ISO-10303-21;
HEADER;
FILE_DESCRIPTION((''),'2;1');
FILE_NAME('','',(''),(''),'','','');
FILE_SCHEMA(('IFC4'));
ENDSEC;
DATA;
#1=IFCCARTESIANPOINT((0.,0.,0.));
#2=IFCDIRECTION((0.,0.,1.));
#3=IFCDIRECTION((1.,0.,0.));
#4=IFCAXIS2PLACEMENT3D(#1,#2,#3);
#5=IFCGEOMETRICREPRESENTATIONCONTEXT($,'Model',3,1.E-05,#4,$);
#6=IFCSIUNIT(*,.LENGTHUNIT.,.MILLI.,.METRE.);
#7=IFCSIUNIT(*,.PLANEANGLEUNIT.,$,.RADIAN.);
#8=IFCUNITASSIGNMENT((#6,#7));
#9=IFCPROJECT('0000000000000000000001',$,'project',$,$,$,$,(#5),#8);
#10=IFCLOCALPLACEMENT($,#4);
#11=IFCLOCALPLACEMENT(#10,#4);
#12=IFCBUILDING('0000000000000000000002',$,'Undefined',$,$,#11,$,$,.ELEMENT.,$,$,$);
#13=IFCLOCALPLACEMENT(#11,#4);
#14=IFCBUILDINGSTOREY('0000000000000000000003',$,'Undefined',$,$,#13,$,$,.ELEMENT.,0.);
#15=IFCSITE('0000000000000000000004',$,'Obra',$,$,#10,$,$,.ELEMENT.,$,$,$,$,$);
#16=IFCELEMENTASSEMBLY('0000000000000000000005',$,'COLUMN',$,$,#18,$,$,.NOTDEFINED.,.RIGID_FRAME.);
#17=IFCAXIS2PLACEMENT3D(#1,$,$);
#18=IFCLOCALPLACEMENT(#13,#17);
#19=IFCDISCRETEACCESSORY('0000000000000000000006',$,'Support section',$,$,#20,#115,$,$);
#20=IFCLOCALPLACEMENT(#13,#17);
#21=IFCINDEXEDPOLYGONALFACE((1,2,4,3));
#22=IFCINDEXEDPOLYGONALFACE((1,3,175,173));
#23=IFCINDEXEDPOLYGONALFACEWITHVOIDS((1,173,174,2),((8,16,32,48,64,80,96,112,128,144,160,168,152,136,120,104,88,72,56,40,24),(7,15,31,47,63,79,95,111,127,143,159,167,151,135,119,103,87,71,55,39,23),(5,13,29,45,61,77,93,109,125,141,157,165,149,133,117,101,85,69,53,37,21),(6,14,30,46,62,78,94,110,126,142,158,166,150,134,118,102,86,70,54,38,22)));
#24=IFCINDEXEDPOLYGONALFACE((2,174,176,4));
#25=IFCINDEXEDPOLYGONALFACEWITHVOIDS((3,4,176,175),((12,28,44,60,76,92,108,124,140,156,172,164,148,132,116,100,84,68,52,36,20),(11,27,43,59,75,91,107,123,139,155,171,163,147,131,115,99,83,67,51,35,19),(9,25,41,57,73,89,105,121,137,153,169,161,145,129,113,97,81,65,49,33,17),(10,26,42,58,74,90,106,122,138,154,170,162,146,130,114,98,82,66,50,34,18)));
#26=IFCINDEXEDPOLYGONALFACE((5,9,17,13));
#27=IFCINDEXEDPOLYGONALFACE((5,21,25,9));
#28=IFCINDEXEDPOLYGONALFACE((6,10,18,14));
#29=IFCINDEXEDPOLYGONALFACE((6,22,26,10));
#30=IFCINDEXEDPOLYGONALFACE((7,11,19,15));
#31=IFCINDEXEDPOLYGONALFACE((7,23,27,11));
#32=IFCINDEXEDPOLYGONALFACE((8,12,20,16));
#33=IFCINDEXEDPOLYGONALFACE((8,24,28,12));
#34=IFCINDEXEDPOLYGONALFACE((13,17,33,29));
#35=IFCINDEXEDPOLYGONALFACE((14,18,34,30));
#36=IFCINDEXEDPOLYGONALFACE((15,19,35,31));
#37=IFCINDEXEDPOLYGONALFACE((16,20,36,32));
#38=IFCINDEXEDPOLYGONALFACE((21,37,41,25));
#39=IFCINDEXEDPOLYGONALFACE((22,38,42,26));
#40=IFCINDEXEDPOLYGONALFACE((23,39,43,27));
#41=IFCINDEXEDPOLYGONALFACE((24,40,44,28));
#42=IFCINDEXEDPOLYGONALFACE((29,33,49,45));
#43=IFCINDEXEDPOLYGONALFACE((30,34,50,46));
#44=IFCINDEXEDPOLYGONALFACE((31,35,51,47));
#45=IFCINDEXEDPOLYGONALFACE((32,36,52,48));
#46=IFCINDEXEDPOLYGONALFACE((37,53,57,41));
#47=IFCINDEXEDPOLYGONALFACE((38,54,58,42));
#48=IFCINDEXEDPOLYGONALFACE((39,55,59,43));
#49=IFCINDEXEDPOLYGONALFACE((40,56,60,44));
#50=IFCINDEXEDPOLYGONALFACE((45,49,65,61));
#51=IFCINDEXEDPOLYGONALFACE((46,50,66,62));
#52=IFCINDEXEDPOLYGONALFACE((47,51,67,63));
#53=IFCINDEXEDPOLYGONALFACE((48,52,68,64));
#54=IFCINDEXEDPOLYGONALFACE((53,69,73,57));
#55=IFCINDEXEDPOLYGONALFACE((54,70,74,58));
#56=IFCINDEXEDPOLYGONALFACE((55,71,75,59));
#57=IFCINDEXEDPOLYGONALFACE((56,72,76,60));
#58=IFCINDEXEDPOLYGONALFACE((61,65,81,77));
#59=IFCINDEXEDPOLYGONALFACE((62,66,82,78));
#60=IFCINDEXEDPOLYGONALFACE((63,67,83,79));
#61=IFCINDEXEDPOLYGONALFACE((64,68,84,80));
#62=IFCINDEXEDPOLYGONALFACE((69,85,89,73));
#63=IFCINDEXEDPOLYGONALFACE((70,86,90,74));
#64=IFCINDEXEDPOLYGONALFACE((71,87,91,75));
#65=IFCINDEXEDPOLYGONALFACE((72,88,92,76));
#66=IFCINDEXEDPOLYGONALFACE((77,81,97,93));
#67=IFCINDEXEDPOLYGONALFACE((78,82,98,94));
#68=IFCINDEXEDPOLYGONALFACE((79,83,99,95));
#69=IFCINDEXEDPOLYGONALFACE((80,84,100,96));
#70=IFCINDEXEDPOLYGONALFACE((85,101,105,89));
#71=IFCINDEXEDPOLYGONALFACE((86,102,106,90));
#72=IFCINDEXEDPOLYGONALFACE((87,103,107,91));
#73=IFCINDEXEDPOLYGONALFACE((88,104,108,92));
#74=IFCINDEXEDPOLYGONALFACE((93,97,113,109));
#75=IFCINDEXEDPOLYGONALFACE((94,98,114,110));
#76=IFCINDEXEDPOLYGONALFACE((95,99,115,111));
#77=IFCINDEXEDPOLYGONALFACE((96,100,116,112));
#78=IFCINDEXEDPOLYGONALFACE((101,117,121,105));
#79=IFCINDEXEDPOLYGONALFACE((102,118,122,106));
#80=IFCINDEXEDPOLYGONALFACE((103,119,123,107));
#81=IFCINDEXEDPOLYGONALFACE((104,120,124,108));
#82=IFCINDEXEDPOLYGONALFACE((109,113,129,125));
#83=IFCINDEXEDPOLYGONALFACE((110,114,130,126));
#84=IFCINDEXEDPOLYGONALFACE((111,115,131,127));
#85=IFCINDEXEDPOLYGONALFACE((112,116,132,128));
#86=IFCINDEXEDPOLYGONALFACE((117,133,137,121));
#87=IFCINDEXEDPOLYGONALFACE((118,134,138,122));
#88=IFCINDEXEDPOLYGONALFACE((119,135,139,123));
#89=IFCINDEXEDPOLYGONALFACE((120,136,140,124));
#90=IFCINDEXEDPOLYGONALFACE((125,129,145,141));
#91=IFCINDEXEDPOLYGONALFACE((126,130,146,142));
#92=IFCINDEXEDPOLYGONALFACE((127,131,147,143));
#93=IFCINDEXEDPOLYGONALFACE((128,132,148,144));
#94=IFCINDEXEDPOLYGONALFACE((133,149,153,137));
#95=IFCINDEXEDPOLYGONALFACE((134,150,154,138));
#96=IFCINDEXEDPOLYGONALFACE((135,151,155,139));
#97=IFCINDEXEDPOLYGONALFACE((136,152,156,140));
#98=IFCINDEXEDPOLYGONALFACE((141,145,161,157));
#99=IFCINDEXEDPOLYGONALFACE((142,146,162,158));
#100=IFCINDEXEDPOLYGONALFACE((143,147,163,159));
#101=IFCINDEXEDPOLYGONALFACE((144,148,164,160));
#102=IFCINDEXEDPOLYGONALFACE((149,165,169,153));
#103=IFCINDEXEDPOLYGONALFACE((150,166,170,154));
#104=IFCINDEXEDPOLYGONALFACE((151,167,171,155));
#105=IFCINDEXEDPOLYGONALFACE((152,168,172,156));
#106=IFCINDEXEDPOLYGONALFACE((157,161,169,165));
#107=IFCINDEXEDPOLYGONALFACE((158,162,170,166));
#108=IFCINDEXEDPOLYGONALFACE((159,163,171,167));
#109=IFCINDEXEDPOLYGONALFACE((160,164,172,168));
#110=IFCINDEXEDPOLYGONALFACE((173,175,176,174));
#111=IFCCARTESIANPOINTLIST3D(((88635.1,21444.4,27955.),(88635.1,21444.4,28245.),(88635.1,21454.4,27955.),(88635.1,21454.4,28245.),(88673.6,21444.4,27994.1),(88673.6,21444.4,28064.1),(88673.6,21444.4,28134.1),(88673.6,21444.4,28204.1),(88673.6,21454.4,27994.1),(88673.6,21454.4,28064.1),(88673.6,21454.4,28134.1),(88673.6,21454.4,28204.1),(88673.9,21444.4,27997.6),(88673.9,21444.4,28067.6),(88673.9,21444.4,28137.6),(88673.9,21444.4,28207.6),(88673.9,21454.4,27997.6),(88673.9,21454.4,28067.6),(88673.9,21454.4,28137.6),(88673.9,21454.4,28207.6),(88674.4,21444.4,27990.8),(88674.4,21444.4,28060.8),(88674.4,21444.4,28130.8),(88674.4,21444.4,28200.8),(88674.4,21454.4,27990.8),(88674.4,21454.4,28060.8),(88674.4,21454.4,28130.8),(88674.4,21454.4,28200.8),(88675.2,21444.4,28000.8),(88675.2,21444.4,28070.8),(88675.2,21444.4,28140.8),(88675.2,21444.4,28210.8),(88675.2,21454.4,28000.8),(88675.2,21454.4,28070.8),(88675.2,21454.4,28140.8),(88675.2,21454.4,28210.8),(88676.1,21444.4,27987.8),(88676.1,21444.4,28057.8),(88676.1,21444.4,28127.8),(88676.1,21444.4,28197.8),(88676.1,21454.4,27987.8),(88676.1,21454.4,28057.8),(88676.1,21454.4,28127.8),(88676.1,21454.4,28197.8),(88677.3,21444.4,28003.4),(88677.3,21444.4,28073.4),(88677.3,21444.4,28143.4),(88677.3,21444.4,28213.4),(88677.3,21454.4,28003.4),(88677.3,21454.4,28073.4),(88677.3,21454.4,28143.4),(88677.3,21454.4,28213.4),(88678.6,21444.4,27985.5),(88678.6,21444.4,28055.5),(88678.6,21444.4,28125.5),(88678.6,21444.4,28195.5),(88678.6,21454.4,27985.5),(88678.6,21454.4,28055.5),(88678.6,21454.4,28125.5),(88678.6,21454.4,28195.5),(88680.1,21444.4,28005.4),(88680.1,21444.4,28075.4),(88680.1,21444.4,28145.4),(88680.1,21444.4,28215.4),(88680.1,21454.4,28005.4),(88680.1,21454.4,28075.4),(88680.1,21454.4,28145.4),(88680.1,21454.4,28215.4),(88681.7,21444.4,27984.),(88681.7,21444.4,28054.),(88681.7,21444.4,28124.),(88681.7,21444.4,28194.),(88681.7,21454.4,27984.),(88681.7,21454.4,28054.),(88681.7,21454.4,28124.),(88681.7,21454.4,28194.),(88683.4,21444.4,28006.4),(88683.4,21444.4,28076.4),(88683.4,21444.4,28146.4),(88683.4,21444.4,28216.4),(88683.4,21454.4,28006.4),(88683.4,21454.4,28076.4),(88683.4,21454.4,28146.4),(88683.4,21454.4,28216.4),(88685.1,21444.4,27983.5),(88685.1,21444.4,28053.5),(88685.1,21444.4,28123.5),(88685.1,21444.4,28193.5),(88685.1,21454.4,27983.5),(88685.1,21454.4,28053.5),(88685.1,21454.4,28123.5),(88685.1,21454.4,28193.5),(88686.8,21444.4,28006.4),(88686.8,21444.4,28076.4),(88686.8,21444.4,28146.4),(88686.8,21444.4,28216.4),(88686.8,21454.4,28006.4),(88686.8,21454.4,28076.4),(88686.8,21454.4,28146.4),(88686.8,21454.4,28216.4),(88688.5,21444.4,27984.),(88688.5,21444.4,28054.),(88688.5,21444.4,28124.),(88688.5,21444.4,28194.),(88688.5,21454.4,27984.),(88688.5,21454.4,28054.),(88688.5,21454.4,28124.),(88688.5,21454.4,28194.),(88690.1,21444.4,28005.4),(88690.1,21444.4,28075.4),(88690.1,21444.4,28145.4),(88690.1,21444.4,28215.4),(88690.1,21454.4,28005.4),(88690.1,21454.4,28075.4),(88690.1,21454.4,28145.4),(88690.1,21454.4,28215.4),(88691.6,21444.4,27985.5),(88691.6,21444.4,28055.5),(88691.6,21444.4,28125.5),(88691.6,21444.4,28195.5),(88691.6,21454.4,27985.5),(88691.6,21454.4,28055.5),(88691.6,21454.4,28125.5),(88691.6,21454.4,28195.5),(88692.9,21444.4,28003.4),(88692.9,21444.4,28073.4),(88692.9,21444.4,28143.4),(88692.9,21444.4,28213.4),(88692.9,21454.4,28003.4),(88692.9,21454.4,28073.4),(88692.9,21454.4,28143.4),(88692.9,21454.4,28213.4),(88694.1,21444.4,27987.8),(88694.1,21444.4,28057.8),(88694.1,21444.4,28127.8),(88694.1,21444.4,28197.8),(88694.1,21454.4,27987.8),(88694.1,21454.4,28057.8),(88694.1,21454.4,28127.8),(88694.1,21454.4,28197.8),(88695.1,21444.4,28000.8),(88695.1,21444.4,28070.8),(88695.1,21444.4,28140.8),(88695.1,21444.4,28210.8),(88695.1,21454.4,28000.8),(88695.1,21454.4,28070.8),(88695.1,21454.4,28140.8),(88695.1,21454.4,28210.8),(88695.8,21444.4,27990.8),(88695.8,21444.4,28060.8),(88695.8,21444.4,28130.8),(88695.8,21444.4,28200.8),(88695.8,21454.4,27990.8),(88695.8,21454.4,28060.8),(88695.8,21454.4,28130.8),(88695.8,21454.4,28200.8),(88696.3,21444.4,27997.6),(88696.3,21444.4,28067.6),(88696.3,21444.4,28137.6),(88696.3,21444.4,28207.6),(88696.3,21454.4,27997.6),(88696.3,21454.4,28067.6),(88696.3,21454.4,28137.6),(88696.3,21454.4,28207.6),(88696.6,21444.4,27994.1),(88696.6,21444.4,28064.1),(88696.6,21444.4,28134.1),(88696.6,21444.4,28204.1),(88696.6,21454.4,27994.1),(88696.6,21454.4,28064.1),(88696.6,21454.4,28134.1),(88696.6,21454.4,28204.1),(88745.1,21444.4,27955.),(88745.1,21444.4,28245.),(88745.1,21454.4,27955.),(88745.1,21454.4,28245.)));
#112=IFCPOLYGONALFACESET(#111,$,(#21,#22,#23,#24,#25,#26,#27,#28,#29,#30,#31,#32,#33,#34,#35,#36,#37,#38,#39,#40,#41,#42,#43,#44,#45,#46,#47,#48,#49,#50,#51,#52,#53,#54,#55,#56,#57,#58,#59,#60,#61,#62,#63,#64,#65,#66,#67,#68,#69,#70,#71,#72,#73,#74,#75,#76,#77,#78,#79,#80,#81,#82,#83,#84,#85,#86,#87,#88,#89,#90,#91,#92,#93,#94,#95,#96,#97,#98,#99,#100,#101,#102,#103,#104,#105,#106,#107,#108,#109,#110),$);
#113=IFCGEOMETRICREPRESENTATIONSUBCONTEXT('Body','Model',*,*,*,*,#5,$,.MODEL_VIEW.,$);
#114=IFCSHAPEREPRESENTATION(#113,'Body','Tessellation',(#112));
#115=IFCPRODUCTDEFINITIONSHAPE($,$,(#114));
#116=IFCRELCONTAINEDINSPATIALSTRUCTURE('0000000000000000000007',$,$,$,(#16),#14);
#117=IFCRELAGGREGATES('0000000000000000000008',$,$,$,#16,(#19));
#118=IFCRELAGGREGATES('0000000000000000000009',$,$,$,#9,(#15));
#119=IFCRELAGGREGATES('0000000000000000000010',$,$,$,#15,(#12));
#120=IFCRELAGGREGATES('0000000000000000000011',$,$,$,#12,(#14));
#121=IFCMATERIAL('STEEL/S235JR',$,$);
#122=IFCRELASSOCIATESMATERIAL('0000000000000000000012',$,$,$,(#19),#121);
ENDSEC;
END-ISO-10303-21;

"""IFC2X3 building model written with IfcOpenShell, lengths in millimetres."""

from ifc_helpers import new_model, si_unit, frame, origin_with_axes, origin_2d_with_axis, place, context, subcontext, project, spatial, rectangle, circle, extrude, source, transform, mapped, material, element, aggregate, save


model = new_model("IFC2X3")

# Units and contexts
model_context = context("Model", 3, precision=1e-05, world=origin_with_axes())
body_context = subcontext(model_context, "Body", "Model", "MODEL_VIEW")
ifc_project = project(units=[si_unit("LENGTHUNIT", "METRE", prefix="MILLI"), si_unit("PLANEANGLEUNIT", "RADIAN")], contexts=[model_context])

# Site, building, storey
site_placement = place(None, origin_with_axes())
site = spatial("IfcSite", under=ifc_project, at=site_placement, Name="Obra", CompositionType="ELEMENT")
building_placement = place(site_placement, origin_with_axes())
building = spatial("IfcBuilding", under=site, at=building_placement, Name="Undefined", CompositionType="ELEMENT")
storey_placement = place(building_placement, origin_with_axes())
storey = spatial("IfcBuildingStorey", under=building, at=storey_placement, Name="Undefined", CompositionType="ELEMENT", Elevation=0.0)

# Element assembly
assembly_1_placement = place(storey_placement, origin_with_axes())
assembly_1 = element("IfcElementAssembly", 1, at=assembly_1_placement, inside=storey, Name="COLUMN", AssemblyPlace="NOTDEFINED", PredefinedType="RIGID_FRAME")
ifc_material = material(Name="STEEL/S235JR")

# Discrete accessory, opening
shared_shape_1 = source(origin_with_axes(), body_context, "Body", "SweptSolid", [
    extrude(circle(Radius=11.5, at=origin_2d_with_axis()), frame((0.0, -14.4, 0.0), z_axis=(0.0, 1.0, 0.0), x_axis=(1.0, 0.0, 0.0)), (0.0, 0.0, 1.0), 10.2),
])
discrete_accessory_1_placement = place(assembly_1_placement, frame((88690.1, 21449.4, 27955.0), z_axis=(0.0, 0.0, 1.0), x_axis=(1.0, 0.0, 0.0)))
discrete_accessory_1 = element("IfcDiscreteAccessory", 2, at=discrete_accessory_1_placement, material=ifc_material, Name="Support section", context=body_context, shape_type="SweptSolid", body=[
    extrude(rectangle(XDim=10.0, YDim=110.0, at=origin_2d_with_axis()), frame((0.0, 0.0, 290.0), z_axis=(0.0, 0.0, -1.0), x_axis=(0.0, 1.0, 0.0)), (0.0, 0.0, 1.0), 290.0),
])
opening_1_placement = place(assembly_1_placement, frame((88735.1, 21440.1, 28300.0), z_axis=(-1.0, 0.0, 0.0), x_axis=(0.0, 0.0, -1.0)))
element("IfcOpeningElement", 3, at=opening_1_placement, cuts=discrete_accessory_1, ObjectType="Opening", context=body_context, shape_type="MappedRepresentation", body=[
    mapped(shared_shape_1, transform((95.0, 0.0, 50.0))),
    mapped(shared_shape_1, transform((165.0, 0.0, 50.0))),
    mapped(shared_shape_1, transform((235.0, 0.0, 50.0))),
    mapped(shared_shape_1, transform((305.0, 0.0, 50.0))),
])
aggregate(assembly_1, [discrete_accessory_1])

save(model, "model.ifc")
